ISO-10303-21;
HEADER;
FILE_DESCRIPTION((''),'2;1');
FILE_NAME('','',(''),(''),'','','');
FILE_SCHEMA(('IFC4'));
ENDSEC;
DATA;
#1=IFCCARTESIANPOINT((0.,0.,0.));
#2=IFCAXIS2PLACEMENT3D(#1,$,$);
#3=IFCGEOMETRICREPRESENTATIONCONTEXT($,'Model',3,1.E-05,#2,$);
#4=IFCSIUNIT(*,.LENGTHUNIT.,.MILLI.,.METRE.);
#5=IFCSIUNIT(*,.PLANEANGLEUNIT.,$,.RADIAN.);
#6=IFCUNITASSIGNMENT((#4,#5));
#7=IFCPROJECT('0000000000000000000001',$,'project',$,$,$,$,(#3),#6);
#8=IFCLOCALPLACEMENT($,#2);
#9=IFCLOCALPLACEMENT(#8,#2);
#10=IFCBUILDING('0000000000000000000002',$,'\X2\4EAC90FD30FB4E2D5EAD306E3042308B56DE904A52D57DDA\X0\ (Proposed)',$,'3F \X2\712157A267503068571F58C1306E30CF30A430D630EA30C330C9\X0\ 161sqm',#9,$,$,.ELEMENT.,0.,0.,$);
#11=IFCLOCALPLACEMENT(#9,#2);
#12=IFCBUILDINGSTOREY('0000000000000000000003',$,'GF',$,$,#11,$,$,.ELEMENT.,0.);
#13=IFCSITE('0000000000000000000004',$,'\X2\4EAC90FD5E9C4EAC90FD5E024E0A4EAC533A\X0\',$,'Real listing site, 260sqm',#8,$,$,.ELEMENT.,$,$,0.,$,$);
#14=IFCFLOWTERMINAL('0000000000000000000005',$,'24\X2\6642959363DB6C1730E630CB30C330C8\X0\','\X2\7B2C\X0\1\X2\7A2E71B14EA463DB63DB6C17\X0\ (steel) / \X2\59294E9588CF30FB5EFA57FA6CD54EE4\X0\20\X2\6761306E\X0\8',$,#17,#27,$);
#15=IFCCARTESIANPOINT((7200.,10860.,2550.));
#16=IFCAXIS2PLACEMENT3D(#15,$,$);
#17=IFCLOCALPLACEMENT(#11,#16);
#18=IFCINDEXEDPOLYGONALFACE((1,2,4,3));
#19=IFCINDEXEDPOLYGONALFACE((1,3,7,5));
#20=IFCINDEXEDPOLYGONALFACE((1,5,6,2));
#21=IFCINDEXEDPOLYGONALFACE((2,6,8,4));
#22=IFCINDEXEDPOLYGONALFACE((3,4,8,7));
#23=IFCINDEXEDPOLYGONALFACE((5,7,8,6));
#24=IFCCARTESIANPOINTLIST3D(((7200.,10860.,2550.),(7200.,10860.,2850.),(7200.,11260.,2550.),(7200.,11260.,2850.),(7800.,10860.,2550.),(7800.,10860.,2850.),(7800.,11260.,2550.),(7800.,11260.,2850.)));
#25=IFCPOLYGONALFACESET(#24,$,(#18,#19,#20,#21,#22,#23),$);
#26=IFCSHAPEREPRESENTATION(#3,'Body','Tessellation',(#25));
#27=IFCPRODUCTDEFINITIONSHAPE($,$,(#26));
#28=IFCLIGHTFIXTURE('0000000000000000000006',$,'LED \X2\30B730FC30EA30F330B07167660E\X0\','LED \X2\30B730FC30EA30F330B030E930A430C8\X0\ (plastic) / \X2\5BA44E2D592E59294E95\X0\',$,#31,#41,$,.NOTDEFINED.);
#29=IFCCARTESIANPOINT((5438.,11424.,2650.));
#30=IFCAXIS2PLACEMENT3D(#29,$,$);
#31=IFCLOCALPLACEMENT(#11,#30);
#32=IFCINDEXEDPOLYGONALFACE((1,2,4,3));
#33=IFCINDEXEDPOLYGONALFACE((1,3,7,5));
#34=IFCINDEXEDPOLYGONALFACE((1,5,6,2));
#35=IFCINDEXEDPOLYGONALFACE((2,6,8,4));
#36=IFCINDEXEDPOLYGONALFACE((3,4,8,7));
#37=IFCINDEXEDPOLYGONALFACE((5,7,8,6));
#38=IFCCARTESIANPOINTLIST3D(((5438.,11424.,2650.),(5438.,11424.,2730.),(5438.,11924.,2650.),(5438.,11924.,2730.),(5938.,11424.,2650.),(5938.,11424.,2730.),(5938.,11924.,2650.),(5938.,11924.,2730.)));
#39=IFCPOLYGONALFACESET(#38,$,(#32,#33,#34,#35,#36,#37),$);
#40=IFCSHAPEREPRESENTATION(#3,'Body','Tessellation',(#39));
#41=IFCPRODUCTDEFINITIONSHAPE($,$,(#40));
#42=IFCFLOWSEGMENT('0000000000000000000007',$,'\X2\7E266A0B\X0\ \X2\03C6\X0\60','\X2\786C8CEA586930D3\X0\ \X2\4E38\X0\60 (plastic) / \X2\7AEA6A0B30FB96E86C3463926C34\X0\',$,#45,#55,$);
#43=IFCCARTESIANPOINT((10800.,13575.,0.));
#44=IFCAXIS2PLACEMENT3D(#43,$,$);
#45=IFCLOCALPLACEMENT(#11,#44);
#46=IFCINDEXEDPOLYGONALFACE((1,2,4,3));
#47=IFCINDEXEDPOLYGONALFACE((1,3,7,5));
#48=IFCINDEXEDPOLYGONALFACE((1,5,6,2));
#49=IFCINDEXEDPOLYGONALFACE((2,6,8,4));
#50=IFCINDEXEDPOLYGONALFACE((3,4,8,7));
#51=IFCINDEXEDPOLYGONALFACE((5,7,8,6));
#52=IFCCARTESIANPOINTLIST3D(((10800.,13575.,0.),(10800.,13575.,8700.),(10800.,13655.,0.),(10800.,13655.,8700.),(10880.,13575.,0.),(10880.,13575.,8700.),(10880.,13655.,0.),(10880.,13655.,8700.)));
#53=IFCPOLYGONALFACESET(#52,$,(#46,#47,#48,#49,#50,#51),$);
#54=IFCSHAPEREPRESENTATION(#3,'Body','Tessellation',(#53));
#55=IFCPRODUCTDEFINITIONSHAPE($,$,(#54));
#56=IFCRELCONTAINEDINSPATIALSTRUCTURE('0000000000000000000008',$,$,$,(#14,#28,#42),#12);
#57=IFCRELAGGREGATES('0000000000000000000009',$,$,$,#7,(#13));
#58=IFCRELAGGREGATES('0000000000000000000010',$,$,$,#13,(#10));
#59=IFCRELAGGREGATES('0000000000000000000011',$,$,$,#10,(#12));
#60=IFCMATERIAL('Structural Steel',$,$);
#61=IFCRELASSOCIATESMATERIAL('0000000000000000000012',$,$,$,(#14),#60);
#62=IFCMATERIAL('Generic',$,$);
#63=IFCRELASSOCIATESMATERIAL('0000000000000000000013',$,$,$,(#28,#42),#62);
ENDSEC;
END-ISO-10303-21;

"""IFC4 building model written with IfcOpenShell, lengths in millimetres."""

from ifc_helpers import new_model, si_unit, frame, frame_2d, origin, place, context, project, spatial, rectangle, extrude, material, element, save


model = new_model("IFC4")

# Units and contexts
model_context = context("Model", 3, precision=1e-05, world=origin())
ifc_project = project(units=[si_unit("LENGTHUNIT", "METRE", prefix="MILLI"), si_unit("PLANEANGLEUNIT", "RADIAN")], contexts=[model_context])

# Site, building, storey
site_placement = place(None, origin())
site = spatial("IfcSite", under=ifc_project, at=site_placement, Name="京都府京都市上京区", ObjectType="Real listing site, 260sqm", CompositionType="ELEMENT", RefElevation=0.0)
building_placement = place(site_placement, origin())
building = spatial("IfcBuilding", under=site, at=building_placement, Name="京都・中庭のある回遊動線 (Proposed)", ObjectType="3F 無垢材と土壁のハイブリッド 161sqm", CompositionType="ELEMENT", ElevationOfRefHeight=0.0, ElevationOfTerrain=0.0)
storey_placement = place(building_placement, origin())
storey = spatial("IfcBuildingStorey", under=building, at=storey_placement, Name="GF", CompositionType="ELEMENT", Elevation=0.0)

# Shared definitions
ifc_material_1 = material(Name="Generic")

# Flow terminal
ifc_material_2 = material(Name="Structural Steel")
flow_terminal_placement = place(storey_placement, frame((7200.0, 10860.0, 2550.0)))
element("IfcFlowTerminal", 1, at=flow_terminal_placement, inside=storey, material=ifc_material_2, Name="24時間換気ユニット", Description="第1種熱交換換気 (steel) / 天井裏・建基法令20条の8", context=model_context, shape_type="SweptSolid", body=[
    extrude(rectangle(XDim=600.0, YDim=400.0, at=frame_2d((300.0, 200.0))), frame((7200.0, 10860.0, 2550.0)), (0.0, 0.0, 1.0), 300.0),
])

# Light fixture
light_fixture_placement = place(storey_placement, frame((5438.0, 11424.0, 2650.0)))
element("IfcLightFixture", 2, at=light_fixture_placement, inside=storey, material=ifc_material_1, Name="LED シーリング照明", Description="LED シーリングライト (plastic) / 室中央天井", PredefinedType="NOTDEFINED", context=model_context, shape_type="SweptSolid", body=[
    extrude(rectangle(XDim=500.0, YDim=500.0, at=frame_2d((250.0, 250.0))), frame((5438.0, 11424.0, 2650.0)), (0.0, 0.0, 1.0), 80.0),
])

# Flow segment
flow_segment_placement = place(storey_placement, frame((10800.0, 13575.0, 0.0)))
element("IfcFlowSegment", 3, at=flow_segment_placement, inside=storey, material=ifc_material_1, Name="縦樋 φ60", Description="硬質塩ビ 丸60 (plastic) / 竪樋・雨水排水", context=model_context, shape_type="SweptSolid", body=[
    extrude(rectangle(XDim=80.0, YDim=80.0, at=frame_2d((40.0, 40.0))), frame((10800.0, 13575.0, 0.0)), (0.0, 0.0, 1.0), 8700.0),
])

save(model, "model.ifc")
